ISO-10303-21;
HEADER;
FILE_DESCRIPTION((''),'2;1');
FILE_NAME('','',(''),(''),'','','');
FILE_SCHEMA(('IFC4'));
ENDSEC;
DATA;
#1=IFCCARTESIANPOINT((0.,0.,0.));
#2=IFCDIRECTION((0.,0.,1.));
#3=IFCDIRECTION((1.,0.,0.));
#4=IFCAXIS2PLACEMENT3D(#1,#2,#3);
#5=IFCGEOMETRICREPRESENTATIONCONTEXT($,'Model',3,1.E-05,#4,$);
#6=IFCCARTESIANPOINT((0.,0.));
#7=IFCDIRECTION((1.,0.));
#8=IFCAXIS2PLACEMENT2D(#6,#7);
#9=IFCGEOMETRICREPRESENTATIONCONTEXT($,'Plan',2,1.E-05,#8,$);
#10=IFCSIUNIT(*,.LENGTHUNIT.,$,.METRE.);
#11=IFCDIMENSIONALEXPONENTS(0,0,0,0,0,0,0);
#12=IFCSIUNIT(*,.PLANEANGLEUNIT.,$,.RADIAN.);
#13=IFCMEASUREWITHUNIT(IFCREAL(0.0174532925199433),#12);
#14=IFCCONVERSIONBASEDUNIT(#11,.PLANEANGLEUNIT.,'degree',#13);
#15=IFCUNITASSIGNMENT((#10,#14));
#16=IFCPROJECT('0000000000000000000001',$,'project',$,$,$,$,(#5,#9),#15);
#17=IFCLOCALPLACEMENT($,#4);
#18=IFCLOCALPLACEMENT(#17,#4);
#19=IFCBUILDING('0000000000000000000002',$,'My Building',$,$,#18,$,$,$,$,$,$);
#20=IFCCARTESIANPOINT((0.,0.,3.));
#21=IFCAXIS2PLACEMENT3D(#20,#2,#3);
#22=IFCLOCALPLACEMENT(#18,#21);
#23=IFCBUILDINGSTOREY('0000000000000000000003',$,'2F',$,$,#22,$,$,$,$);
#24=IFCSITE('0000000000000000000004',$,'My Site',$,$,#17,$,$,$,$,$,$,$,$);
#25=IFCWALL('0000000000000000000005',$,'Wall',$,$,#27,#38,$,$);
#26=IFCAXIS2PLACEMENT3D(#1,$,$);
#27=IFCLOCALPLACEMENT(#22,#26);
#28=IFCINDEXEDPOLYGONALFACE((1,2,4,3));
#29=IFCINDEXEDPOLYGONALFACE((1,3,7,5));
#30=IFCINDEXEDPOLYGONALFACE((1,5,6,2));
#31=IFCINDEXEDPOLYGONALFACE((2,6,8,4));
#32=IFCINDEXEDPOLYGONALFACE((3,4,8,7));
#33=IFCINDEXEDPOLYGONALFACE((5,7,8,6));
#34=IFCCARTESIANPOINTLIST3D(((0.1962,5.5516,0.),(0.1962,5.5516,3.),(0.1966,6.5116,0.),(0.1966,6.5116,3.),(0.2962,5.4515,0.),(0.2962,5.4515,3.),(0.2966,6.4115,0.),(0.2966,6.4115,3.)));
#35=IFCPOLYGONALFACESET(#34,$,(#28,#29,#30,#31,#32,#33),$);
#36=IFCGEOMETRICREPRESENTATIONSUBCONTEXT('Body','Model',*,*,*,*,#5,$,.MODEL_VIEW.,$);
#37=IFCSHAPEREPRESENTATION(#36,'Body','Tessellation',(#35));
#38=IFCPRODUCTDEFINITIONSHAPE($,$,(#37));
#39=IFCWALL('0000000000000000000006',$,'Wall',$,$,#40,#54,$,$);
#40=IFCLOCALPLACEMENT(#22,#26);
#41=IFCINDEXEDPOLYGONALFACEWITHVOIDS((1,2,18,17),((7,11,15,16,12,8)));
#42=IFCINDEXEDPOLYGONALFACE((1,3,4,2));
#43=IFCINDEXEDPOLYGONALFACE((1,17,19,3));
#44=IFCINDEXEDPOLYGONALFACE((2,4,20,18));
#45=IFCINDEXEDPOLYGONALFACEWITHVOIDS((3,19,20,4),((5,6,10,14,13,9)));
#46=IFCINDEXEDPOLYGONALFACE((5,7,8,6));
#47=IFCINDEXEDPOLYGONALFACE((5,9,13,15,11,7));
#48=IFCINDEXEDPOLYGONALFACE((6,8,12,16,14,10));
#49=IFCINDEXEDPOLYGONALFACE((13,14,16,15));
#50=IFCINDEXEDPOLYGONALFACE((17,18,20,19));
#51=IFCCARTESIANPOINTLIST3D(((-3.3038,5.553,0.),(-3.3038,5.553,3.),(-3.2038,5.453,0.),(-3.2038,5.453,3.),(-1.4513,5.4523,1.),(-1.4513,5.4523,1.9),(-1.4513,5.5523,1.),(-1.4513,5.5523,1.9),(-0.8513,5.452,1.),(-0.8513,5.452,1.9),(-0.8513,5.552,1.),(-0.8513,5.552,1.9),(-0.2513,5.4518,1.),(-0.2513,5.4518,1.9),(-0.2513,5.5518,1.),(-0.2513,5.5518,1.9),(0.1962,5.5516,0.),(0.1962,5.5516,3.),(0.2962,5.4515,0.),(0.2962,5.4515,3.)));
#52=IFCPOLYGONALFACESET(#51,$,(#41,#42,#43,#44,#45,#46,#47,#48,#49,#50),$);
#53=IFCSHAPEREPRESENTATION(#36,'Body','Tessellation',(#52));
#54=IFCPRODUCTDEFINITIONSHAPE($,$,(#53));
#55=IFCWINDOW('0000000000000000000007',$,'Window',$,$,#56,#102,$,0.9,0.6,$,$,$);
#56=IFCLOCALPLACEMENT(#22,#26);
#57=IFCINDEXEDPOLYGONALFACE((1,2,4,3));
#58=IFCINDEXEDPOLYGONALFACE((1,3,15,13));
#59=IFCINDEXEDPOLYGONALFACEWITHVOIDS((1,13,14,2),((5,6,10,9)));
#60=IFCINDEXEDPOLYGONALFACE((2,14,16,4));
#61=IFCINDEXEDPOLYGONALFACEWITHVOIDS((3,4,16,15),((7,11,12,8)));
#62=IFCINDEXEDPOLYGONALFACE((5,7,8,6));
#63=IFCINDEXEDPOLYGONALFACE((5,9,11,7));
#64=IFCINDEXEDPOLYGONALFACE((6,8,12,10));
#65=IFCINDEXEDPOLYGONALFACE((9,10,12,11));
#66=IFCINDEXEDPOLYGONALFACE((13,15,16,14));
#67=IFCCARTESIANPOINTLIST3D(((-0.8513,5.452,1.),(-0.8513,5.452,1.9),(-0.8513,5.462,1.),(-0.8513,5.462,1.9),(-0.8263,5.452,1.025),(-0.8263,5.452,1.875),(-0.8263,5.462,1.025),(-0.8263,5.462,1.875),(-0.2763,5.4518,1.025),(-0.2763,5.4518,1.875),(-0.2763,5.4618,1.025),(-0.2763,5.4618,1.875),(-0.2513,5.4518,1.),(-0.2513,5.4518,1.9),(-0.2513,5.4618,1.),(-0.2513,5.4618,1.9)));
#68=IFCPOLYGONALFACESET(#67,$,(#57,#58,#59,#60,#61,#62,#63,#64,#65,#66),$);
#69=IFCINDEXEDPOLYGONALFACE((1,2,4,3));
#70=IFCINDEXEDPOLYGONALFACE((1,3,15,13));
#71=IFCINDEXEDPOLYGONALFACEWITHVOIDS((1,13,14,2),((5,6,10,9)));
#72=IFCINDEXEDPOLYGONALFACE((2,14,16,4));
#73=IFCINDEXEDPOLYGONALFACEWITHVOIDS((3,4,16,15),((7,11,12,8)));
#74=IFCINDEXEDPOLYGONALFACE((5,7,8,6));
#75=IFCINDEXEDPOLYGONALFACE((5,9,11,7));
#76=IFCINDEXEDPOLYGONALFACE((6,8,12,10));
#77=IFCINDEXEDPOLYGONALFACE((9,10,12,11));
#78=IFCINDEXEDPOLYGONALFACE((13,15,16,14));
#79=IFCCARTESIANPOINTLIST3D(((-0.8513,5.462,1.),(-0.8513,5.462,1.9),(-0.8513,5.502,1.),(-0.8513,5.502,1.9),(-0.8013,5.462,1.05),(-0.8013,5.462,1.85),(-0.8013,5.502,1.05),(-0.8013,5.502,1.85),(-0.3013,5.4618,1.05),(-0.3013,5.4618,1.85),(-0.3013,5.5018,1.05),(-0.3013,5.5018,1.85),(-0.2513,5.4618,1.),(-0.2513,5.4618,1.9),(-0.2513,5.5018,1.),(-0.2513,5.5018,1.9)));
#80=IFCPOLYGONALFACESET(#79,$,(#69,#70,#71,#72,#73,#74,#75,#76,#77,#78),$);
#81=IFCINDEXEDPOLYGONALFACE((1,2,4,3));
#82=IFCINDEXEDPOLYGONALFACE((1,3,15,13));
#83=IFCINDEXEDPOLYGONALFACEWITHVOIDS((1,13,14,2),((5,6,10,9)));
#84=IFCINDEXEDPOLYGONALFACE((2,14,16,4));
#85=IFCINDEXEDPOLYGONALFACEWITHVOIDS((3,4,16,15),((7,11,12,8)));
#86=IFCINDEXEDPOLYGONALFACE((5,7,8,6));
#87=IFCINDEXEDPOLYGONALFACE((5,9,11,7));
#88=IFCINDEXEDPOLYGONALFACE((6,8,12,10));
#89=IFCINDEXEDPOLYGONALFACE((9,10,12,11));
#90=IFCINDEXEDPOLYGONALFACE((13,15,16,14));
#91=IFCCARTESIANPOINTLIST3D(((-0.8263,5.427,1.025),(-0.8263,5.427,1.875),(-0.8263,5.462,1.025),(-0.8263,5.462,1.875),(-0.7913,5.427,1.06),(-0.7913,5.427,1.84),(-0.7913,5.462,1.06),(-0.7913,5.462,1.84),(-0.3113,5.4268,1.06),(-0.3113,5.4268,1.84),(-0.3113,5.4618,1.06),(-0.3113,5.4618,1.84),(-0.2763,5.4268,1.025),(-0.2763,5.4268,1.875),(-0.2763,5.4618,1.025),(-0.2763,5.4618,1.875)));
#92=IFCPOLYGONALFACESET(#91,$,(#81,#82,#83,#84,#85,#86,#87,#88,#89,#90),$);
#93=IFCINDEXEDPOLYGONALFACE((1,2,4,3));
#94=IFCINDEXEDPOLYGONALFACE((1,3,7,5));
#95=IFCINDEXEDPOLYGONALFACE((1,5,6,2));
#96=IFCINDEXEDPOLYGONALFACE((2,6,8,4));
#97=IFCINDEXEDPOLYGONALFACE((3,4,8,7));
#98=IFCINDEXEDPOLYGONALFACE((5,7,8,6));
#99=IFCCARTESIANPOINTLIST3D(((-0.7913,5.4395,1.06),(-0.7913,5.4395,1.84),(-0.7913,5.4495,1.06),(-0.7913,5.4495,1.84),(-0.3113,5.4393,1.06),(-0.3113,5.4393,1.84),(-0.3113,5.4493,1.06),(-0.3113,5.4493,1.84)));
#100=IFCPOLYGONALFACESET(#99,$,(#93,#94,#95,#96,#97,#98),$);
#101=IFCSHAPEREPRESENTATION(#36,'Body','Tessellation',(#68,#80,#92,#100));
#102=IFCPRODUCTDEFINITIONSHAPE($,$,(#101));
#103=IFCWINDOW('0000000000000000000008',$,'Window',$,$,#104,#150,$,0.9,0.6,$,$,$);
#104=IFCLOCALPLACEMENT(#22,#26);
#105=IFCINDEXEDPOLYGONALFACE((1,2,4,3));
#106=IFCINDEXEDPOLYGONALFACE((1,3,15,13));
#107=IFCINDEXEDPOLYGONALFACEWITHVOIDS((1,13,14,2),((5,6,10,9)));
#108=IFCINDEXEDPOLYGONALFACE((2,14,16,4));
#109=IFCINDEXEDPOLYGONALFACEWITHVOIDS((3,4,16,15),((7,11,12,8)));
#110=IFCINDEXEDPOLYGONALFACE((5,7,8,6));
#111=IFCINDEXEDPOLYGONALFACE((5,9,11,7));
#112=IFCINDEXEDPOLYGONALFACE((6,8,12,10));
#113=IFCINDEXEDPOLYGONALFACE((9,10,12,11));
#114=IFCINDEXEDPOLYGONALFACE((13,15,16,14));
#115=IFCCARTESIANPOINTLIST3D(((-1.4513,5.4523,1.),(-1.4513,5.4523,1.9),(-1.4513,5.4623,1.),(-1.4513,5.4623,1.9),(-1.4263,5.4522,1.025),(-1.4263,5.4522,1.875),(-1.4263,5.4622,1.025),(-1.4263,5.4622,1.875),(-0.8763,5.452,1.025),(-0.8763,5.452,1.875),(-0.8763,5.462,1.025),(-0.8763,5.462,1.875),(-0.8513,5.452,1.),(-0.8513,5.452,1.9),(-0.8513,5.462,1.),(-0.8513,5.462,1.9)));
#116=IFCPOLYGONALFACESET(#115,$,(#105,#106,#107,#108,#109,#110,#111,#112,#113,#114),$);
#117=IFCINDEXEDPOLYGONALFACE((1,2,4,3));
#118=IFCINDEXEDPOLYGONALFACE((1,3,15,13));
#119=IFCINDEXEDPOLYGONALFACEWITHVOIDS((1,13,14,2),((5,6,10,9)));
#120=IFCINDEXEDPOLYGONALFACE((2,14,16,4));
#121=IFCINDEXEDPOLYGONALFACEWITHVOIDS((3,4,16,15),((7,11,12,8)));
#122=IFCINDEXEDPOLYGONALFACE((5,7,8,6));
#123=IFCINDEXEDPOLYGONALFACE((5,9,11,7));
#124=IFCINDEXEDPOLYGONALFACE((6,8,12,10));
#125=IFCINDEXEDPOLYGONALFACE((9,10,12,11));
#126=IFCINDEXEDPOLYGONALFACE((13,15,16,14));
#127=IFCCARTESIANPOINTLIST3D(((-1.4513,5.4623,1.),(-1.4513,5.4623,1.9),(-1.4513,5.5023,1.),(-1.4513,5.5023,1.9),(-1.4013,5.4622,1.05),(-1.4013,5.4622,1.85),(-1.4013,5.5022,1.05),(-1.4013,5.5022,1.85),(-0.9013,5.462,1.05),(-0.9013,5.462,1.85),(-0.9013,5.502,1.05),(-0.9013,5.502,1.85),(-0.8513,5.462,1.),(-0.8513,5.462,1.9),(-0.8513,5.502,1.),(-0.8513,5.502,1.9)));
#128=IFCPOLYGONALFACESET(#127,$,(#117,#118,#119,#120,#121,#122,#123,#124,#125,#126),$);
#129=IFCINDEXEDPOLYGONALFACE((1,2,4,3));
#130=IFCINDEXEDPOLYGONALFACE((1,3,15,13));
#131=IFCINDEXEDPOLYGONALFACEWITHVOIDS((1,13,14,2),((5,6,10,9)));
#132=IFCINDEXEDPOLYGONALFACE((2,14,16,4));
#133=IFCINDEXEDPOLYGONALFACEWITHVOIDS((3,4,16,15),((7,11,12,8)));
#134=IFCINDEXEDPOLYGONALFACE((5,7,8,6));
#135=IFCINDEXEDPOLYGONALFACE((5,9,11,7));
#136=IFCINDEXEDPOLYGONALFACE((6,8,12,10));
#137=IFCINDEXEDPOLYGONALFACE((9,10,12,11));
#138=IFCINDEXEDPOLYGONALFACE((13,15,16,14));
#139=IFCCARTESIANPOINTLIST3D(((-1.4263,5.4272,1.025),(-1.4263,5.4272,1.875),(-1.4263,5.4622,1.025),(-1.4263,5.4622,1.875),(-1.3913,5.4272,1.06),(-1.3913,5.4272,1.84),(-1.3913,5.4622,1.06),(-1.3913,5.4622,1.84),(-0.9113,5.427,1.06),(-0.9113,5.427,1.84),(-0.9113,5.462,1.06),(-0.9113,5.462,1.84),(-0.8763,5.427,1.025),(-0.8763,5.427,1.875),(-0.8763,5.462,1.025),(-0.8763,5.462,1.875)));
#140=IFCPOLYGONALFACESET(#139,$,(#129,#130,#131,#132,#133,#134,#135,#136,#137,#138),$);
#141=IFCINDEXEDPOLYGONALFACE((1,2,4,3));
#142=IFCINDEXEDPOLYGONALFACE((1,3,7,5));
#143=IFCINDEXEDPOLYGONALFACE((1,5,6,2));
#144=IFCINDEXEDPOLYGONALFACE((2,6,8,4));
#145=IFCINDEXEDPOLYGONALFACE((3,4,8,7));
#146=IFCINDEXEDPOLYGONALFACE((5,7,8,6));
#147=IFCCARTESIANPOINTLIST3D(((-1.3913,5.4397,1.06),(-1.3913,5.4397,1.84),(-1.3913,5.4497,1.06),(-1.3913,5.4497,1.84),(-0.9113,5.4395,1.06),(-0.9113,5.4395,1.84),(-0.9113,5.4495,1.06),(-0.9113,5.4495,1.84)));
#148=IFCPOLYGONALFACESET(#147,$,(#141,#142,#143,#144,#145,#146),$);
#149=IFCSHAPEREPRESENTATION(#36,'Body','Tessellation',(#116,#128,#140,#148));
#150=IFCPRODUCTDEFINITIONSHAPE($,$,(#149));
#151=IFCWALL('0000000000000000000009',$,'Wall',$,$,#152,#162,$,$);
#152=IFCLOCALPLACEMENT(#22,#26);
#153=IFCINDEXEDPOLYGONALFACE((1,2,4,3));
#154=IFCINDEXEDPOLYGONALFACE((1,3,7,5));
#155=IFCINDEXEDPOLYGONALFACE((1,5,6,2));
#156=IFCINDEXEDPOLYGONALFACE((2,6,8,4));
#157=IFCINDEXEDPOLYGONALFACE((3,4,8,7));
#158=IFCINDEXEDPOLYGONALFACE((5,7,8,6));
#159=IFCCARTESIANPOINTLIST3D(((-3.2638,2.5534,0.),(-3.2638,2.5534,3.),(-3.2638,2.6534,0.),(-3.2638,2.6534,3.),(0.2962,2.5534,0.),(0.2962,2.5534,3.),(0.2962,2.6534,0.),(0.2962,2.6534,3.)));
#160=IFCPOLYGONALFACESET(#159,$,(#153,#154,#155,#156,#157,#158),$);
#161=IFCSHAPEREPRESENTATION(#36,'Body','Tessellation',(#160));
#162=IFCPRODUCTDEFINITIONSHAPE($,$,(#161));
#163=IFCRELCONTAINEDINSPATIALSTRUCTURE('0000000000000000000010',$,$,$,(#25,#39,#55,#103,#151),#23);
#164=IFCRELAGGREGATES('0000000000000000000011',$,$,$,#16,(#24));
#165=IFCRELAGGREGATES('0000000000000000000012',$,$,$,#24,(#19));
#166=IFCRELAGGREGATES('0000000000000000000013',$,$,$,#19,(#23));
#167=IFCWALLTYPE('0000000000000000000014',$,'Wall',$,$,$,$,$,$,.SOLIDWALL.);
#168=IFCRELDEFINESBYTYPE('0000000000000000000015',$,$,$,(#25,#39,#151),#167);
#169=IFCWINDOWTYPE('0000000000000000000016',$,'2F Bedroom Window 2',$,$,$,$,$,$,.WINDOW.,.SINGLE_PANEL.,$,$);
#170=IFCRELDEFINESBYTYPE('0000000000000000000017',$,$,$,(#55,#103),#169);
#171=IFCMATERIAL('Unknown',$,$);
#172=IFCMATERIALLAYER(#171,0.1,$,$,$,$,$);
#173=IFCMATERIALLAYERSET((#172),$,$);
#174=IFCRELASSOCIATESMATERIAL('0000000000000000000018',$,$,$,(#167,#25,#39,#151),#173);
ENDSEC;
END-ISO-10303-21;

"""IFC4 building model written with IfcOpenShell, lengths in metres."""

from ifc_helpers import new_model, entity, si_unit, converted_unit, frame, origin_with_axes, origin_2d_with_axis, place, context, subcontext, project, spatial, line, indexed_curve, outline, extrude, shape, source, transform, mapped, material, layer, layer_set, layer_usage, type_object, type_shapes, element, fill, save


model = new_model("IFC4")

# Units and contexts
model_context = context("Model", 3, precision=1e-05, world=origin_with_axes())
plan_context = context("Plan", 2, precision=1e-05, world=origin_2d_with_axis())
body_context_1 = subcontext(model_context, "Body", "Model", "MODEL_VIEW")
body_context_2 = subcontext(plan_context, "Body", "Plan", "PLAN_VIEW")
ifc_project = project(units=[si_unit("LENGTHUNIT", "METRE"), converted_unit("PLANEANGLEUNIT", "degree", entity("IfcReal", 0.0174532925199433), si_unit("PLANEANGLEUNIT", "RADIAN"), dimensions=[0, 0, 0, 0, 0, 0, 0])], contexts=[model_context, plan_context])

# Site, building, storey
site_placement = place(None, origin_with_axes())
site = spatial("IfcSite", under=ifc_project, at=site_placement, Name="My Site")
building_placement = place(site_placement, origin_with_axes())
building = spatial("IfcBuilding", under=site, at=building_placement, Name="My Building")
storey_placement = place(building_placement, frame((0.0, 0.0, 3.0), z_axis=(0.0, 0.0, 1.0), x_axis=(1.0, 0.0, 0.0)))
storey = spatial("IfcBuildingStorey", under=building, at=storey_placement, Name="2F")

# Shared definitions
ifc_material = material(Name="Unknown")

# Shared definitions
ifc_layer_1 = layer(ifc_material, 0.1)
ifc_layer_set_1 = layer_set([ifc_layer_1])
wall_type = type_object("IfcWallType", Name="Wall", PredefinedType="SOLIDWALL", material=ifc_layer_set_1)

# Wall
ifc_layer_usage_1 = layer_usage(ifc_layer_set_1, "AXIS2", "POSITIVE", 0.0)
wall_1_placement = place(storey_placement, frame((0.1966, 6.5116, 0.0), z_axis=(0.0, 0.0, 1.0), x_axis=(-0.000415, -1.0, 0.0)))
element("IfcWall", 1, at=wall_1_placement, inside=storey, type_object=wall_type, material=ifc_layer_usage_1, Name="Wall", context=body_context_1, shape_type="SweptSolid", body=[
    extrude(outline(indexed_curve([(0.0, 0.0), (0.1, 0.1), (1.06, 0.1), (0.96, 0.0)], segments=[line(1, 2, 3, 4, 1)])), origin_with_axes(), (0.0, 0.0, 1.0), 3.0),
])

# Wall, openings, windows
ifc_layer_usage_2 = layer_usage(ifc_layer_set_1, "AXIS2", "POSITIVE", 0.0)
wall_2_placement = place(storey_placement, frame((0.1962, 5.5516, 0.0), z_axis=(0.0, 0.0, 1.0), x_axis=(-1.0, 0.000416, 0.0)))
wall_2 = element("IfcWall", 2, at=wall_2_placement, inside=storey, type_object=wall_type, material=ifc_layer_usage_2, Name="Wall", context=body_context_1, shape_type="SweptSolid", body=[
    extrude(outline(indexed_curve([(0.0, 0.0), (-0.1, 0.1), (3.4, 0.1), (3.5, 0.0)], segments=[line(1, 2, 3, 4, 1)])), origin_with_axes(), (0.0, 0.0, 1.0), 3.0),
])
shared_shape_1 = source(origin_with_axes(), body_context_1, "Body", "SweptSolid", [
    extrude(outline(indexed_curve([(0.0, 0.0), (0.6, 0.0), (0.6, 0.9), (0.0, 0.9)], segments=[line(1, 2, 3, 4, 1)])), frame((0.0, -0.6, 0.0), z_axis=(0.0, -1.0, 0.0), x_axis=(1.0, 0.0, 0.0)), (0.0, 0.0, -1.0), 1.2),
])
opening_1_placement = place(wall_2_placement, frame((0.4475, 0.0, 1.0), z_axis=(0.0, 0.0, 1.0), x_axis=(1.0, 0.0, 0.0)))
opening_1 = element("IfcOpeningElement", 3, at=opening_1_placement, cuts=wall_2, PredefinedType="OPENING", context=body_context_1, shape_type="MappedRepresentation", body=[
    mapped(shared_shape_1, transform((0.0, 0.0, 0.0), x_axis=(1.0, 0.0, 0.0), y_axis=(0.0, 1.0, 0.0), z_axis=(0.0, 0.0, 1.0), scale=1.0)),
])
opening_2_placement = place(wall_2_placement, frame((1.0475, 0.0, 1.0), z_axis=(0.0, 0.0, 1.0), x_axis=(1.0, 0.0, 0.0)))
opening_2 = element("IfcOpeningElement", 4, at=opening_2_placement, cuts=wall_2, PredefinedType="OPENING", context=body_context_1, shape_type="MappedRepresentation", body=[
    mapped(shared_shape_1, transform((0.0, 0.0, 0.0), x_axis=(1.0, 0.0, 0.0), y_axis=(0.0, 1.0, 0.0), z_axis=(0.0, 0.0, 1.0), scale=1.0)),
])
window_type_1 = type_object("IfcWindowType", Name="2F Bedroom Window 2", PartitioningType="SINGLE_PANEL", PredefinedType="WINDOW")
shared_shape_2 = source(origin_with_axes(), body_context_1, "Body", "SweptSolid", [
    extrude(outline(indexed_curve([(0.0, 0.0), (0.6, 0.0), (0.6, 0.9), (0.0, 0.9)], segments=[line(1, 2, 3, 4, 1)]), holes=[indexed_curve([(0.025, 0.025), (0.575, 0.025), (0.575, 0.875), (0.025, 0.875)], segments=[line(1, 2, 3, 4, 1)])]), frame((0.0, 0.09, 0.0), z_axis=(0.0, -1.0, 0.0), x_axis=(1.0, 0.0, 0.0)), (0.0, 0.0, -1.0), 0.01),
    extrude(outline(indexed_curve([(0.0, 0.0), (0.6, 0.0), (0.6, 0.9), (0.0, 0.9)], segments=[line(1, 2, 3, 4, 1)]), holes=[indexed_curve([(0.05, 0.05), (0.55, 0.05), (0.55, 0.85), (0.05, 0.85)], segments=[line(1, 2, 3, 4, 1)])]), frame((0.0, 0.05, 0.0), z_axis=(0.0, -1.0, 0.0), x_axis=(1.0, 0.0, 0.0)), (0.0, 0.0, -1.0), 0.04),
    extrude(outline(indexed_curve([(0.0, 0.0), (0.55, 0.0), (0.55, 0.85), (0.0, 0.85)], segments=[line(1, 2, 3, 4, 1)]), holes=[indexed_curve([(0.035, 0.035), (0.515, 0.035), (0.515, 0.815), (0.035, 0.815)], segments=[line(1, 2, 3, 4, 1)])]), frame((0.025, 0.09, 0.025), z_axis=(0.0, -1.0, 0.0), x_axis=(1.0, 0.0, 0.0)), (0.0, 0.0, -1.0), 0.035),
    extrude(outline(indexed_curve([(0.035, 0.035), (0.515, 0.035), (0.515, 0.815), (0.035, 0.815)], segments=[line(1, 2, 3, 4, 1)])), frame((0.025, 0.1025, 0.025), z_axis=(0.0, -1.0, 0.0), x_axis=(1.0, 0.0, 0.0)), (0.0, 0.0, -1.0), 0.01),
])
shared_shape_3 = source(origin_with_axes(), body_context_2, "Body", "Curve2D", [
    entity("IfcIndexedPolyCurve", entity("IfcCartesianPointList2D", [[0.05, 0.05], [0.55, 0.05]])),
    entity("IfcIndexedPolyCurve", entity("IfcCartesianPointList2D", [[0.0, 0.1], [0.025, 0.1], [0.025, 0.09], [0.05, 0.09], [0.05, 0.05], [0.0, 0.05]]), [entity("IfcLineIndex", [1, 2, 3, 4, 5, 6, 1])]),
    entity("IfcIndexedPolyCurve", entity("IfcCartesianPointList2D", [[0.6, 0.1], [0.575, 0.1], [0.575, 0.09], [0.55, 0.09], [0.55, 0.05], [0.6, 0.05]]), [entity("IfcLineIndex", [1, 2, 3, 4, 5, 6, 1])]),
    entity("IfcIndexedPolyCurve", entity("IfcCartesianPointList2D", [[0.025, 0.09], [0.06, 0.09], [0.06, 0.125], [0.025, 0.125]]), [entity("IfcLineIndex", [1, 2, 3, 4, 1])]),
    entity("IfcIndexedPolyCurve", entity("IfcCartesianPointList2D", [[0.575, 0.09], [0.54, 0.09], [0.54, 0.125], [0.575, 0.125]]), [entity("IfcLineIndex", [1, 2, 3, 4, 1])]),
    entity("IfcIndexedPolyCurve", entity("IfcCartesianPointList2D", [[0.06, 0.09], [0.54, 0.09]])),
    entity("IfcIndexedPolyCurve", entity("IfcCartesianPointList2D", [[0.06, 0.125], [0.54, 0.125]])),
    entity("IfcIndexedPolyCurve", entity("IfcCartesianPointList2D", [[0.06, 0.1075], [0.54, 0.1075]])),
])
type_shapes(window_type_1, [shared_shape_2, shared_shape_3])
window_1_placement = place(opening_1_placement, frame((0.0, 0.0, 0.0), z_axis=(0.0, 0.0, 1.0), x_axis=(1.0, 0.0, 0.0)))
window_1 = element("IfcWindow", 5, at=window_1_placement, inside=storey, type_object=window_type_1, Name="Window", OverallHeight=0.9, OverallWidth=0.6, shapes=[
    shape(body_context_1, "Body", "MappedRepresentation", [mapped(shared_shape_2, transform((0.0, 0.0, 0.0), x_axis=(1.0, 0.0, 0.0), y_axis=(0.0, 1.0, 0.0), z_axis=(0.0, 0.0, 1.0), scale=1.0))]),
    shape(body_context_2, "Body", "MappedRepresentation", [mapped(shared_shape_3, transform((0.0, 0.0, 0.0), x_axis=(1.0, 0.0, 0.0), y_axis=(0.0, 1.0, 0.0), z_axis=(0.0, 0.0, 1.0), scale=1.0))]),
])
fill(opening_1, window_1)
window_2_placement = place(opening_2_placement, origin_with_axes())
window_2 = element("IfcWindow", 6, at=window_2_placement, inside=storey, type_object=window_type_1, Name="Window", OverallHeight=0.9, OverallWidth=0.6, shapes=[
    shape(body_context_1, "Body", "MappedRepresentation", [mapped(shared_shape_2, transform((0.0, 0.0, 0.0), x_axis=(1.0, 0.0, 0.0), y_axis=(0.0, 1.0, 0.0), z_axis=(0.0, 0.0, 1.0), scale=1.0))]),
    shape(body_context_2, "Body", "MappedRepresentation", [mapped(shared_shape_3, transform((0.0, 0.0, 0.0), x_axis=(1.0, 0.0, 0.0), y_axis=(0.0, 1.0, 0.0), z_axis=(0.0, 0.0, 1.0), scale=1.0))]),
])
fill(opening_2, window_2)

# Wall
ifc_layer_usage_3 = layer_usage(ifc_layer_set_1, "AXIS2", "POSITIVE", 0.0)
wall_3_placement = place(storey_placement, frame((-3.2638, 2.5534, 0.0), z_axis=(0.0, 0.0, 1.0), x_axis=(1.0, 0.0, 0.0)))
element("IfcWall", 7, at=wall_3_placement, inside=storey, type_object=wall_type, material=ifc_layer_usage_3, Name="Wall", context=body_context_1, shape_type="SweptSolid", body=[
    extrude(outline(indexed_curve([(0.0, 0.0), (0.0, 0.1), (3.56, 0.1), (3.56, 0.0)], segments=[line(1, 2, 3, 4, 1)])), origin_with_axes(), (0.0, 0.0, 1.0), 3.0),
])

save(model, "model.ifc")
